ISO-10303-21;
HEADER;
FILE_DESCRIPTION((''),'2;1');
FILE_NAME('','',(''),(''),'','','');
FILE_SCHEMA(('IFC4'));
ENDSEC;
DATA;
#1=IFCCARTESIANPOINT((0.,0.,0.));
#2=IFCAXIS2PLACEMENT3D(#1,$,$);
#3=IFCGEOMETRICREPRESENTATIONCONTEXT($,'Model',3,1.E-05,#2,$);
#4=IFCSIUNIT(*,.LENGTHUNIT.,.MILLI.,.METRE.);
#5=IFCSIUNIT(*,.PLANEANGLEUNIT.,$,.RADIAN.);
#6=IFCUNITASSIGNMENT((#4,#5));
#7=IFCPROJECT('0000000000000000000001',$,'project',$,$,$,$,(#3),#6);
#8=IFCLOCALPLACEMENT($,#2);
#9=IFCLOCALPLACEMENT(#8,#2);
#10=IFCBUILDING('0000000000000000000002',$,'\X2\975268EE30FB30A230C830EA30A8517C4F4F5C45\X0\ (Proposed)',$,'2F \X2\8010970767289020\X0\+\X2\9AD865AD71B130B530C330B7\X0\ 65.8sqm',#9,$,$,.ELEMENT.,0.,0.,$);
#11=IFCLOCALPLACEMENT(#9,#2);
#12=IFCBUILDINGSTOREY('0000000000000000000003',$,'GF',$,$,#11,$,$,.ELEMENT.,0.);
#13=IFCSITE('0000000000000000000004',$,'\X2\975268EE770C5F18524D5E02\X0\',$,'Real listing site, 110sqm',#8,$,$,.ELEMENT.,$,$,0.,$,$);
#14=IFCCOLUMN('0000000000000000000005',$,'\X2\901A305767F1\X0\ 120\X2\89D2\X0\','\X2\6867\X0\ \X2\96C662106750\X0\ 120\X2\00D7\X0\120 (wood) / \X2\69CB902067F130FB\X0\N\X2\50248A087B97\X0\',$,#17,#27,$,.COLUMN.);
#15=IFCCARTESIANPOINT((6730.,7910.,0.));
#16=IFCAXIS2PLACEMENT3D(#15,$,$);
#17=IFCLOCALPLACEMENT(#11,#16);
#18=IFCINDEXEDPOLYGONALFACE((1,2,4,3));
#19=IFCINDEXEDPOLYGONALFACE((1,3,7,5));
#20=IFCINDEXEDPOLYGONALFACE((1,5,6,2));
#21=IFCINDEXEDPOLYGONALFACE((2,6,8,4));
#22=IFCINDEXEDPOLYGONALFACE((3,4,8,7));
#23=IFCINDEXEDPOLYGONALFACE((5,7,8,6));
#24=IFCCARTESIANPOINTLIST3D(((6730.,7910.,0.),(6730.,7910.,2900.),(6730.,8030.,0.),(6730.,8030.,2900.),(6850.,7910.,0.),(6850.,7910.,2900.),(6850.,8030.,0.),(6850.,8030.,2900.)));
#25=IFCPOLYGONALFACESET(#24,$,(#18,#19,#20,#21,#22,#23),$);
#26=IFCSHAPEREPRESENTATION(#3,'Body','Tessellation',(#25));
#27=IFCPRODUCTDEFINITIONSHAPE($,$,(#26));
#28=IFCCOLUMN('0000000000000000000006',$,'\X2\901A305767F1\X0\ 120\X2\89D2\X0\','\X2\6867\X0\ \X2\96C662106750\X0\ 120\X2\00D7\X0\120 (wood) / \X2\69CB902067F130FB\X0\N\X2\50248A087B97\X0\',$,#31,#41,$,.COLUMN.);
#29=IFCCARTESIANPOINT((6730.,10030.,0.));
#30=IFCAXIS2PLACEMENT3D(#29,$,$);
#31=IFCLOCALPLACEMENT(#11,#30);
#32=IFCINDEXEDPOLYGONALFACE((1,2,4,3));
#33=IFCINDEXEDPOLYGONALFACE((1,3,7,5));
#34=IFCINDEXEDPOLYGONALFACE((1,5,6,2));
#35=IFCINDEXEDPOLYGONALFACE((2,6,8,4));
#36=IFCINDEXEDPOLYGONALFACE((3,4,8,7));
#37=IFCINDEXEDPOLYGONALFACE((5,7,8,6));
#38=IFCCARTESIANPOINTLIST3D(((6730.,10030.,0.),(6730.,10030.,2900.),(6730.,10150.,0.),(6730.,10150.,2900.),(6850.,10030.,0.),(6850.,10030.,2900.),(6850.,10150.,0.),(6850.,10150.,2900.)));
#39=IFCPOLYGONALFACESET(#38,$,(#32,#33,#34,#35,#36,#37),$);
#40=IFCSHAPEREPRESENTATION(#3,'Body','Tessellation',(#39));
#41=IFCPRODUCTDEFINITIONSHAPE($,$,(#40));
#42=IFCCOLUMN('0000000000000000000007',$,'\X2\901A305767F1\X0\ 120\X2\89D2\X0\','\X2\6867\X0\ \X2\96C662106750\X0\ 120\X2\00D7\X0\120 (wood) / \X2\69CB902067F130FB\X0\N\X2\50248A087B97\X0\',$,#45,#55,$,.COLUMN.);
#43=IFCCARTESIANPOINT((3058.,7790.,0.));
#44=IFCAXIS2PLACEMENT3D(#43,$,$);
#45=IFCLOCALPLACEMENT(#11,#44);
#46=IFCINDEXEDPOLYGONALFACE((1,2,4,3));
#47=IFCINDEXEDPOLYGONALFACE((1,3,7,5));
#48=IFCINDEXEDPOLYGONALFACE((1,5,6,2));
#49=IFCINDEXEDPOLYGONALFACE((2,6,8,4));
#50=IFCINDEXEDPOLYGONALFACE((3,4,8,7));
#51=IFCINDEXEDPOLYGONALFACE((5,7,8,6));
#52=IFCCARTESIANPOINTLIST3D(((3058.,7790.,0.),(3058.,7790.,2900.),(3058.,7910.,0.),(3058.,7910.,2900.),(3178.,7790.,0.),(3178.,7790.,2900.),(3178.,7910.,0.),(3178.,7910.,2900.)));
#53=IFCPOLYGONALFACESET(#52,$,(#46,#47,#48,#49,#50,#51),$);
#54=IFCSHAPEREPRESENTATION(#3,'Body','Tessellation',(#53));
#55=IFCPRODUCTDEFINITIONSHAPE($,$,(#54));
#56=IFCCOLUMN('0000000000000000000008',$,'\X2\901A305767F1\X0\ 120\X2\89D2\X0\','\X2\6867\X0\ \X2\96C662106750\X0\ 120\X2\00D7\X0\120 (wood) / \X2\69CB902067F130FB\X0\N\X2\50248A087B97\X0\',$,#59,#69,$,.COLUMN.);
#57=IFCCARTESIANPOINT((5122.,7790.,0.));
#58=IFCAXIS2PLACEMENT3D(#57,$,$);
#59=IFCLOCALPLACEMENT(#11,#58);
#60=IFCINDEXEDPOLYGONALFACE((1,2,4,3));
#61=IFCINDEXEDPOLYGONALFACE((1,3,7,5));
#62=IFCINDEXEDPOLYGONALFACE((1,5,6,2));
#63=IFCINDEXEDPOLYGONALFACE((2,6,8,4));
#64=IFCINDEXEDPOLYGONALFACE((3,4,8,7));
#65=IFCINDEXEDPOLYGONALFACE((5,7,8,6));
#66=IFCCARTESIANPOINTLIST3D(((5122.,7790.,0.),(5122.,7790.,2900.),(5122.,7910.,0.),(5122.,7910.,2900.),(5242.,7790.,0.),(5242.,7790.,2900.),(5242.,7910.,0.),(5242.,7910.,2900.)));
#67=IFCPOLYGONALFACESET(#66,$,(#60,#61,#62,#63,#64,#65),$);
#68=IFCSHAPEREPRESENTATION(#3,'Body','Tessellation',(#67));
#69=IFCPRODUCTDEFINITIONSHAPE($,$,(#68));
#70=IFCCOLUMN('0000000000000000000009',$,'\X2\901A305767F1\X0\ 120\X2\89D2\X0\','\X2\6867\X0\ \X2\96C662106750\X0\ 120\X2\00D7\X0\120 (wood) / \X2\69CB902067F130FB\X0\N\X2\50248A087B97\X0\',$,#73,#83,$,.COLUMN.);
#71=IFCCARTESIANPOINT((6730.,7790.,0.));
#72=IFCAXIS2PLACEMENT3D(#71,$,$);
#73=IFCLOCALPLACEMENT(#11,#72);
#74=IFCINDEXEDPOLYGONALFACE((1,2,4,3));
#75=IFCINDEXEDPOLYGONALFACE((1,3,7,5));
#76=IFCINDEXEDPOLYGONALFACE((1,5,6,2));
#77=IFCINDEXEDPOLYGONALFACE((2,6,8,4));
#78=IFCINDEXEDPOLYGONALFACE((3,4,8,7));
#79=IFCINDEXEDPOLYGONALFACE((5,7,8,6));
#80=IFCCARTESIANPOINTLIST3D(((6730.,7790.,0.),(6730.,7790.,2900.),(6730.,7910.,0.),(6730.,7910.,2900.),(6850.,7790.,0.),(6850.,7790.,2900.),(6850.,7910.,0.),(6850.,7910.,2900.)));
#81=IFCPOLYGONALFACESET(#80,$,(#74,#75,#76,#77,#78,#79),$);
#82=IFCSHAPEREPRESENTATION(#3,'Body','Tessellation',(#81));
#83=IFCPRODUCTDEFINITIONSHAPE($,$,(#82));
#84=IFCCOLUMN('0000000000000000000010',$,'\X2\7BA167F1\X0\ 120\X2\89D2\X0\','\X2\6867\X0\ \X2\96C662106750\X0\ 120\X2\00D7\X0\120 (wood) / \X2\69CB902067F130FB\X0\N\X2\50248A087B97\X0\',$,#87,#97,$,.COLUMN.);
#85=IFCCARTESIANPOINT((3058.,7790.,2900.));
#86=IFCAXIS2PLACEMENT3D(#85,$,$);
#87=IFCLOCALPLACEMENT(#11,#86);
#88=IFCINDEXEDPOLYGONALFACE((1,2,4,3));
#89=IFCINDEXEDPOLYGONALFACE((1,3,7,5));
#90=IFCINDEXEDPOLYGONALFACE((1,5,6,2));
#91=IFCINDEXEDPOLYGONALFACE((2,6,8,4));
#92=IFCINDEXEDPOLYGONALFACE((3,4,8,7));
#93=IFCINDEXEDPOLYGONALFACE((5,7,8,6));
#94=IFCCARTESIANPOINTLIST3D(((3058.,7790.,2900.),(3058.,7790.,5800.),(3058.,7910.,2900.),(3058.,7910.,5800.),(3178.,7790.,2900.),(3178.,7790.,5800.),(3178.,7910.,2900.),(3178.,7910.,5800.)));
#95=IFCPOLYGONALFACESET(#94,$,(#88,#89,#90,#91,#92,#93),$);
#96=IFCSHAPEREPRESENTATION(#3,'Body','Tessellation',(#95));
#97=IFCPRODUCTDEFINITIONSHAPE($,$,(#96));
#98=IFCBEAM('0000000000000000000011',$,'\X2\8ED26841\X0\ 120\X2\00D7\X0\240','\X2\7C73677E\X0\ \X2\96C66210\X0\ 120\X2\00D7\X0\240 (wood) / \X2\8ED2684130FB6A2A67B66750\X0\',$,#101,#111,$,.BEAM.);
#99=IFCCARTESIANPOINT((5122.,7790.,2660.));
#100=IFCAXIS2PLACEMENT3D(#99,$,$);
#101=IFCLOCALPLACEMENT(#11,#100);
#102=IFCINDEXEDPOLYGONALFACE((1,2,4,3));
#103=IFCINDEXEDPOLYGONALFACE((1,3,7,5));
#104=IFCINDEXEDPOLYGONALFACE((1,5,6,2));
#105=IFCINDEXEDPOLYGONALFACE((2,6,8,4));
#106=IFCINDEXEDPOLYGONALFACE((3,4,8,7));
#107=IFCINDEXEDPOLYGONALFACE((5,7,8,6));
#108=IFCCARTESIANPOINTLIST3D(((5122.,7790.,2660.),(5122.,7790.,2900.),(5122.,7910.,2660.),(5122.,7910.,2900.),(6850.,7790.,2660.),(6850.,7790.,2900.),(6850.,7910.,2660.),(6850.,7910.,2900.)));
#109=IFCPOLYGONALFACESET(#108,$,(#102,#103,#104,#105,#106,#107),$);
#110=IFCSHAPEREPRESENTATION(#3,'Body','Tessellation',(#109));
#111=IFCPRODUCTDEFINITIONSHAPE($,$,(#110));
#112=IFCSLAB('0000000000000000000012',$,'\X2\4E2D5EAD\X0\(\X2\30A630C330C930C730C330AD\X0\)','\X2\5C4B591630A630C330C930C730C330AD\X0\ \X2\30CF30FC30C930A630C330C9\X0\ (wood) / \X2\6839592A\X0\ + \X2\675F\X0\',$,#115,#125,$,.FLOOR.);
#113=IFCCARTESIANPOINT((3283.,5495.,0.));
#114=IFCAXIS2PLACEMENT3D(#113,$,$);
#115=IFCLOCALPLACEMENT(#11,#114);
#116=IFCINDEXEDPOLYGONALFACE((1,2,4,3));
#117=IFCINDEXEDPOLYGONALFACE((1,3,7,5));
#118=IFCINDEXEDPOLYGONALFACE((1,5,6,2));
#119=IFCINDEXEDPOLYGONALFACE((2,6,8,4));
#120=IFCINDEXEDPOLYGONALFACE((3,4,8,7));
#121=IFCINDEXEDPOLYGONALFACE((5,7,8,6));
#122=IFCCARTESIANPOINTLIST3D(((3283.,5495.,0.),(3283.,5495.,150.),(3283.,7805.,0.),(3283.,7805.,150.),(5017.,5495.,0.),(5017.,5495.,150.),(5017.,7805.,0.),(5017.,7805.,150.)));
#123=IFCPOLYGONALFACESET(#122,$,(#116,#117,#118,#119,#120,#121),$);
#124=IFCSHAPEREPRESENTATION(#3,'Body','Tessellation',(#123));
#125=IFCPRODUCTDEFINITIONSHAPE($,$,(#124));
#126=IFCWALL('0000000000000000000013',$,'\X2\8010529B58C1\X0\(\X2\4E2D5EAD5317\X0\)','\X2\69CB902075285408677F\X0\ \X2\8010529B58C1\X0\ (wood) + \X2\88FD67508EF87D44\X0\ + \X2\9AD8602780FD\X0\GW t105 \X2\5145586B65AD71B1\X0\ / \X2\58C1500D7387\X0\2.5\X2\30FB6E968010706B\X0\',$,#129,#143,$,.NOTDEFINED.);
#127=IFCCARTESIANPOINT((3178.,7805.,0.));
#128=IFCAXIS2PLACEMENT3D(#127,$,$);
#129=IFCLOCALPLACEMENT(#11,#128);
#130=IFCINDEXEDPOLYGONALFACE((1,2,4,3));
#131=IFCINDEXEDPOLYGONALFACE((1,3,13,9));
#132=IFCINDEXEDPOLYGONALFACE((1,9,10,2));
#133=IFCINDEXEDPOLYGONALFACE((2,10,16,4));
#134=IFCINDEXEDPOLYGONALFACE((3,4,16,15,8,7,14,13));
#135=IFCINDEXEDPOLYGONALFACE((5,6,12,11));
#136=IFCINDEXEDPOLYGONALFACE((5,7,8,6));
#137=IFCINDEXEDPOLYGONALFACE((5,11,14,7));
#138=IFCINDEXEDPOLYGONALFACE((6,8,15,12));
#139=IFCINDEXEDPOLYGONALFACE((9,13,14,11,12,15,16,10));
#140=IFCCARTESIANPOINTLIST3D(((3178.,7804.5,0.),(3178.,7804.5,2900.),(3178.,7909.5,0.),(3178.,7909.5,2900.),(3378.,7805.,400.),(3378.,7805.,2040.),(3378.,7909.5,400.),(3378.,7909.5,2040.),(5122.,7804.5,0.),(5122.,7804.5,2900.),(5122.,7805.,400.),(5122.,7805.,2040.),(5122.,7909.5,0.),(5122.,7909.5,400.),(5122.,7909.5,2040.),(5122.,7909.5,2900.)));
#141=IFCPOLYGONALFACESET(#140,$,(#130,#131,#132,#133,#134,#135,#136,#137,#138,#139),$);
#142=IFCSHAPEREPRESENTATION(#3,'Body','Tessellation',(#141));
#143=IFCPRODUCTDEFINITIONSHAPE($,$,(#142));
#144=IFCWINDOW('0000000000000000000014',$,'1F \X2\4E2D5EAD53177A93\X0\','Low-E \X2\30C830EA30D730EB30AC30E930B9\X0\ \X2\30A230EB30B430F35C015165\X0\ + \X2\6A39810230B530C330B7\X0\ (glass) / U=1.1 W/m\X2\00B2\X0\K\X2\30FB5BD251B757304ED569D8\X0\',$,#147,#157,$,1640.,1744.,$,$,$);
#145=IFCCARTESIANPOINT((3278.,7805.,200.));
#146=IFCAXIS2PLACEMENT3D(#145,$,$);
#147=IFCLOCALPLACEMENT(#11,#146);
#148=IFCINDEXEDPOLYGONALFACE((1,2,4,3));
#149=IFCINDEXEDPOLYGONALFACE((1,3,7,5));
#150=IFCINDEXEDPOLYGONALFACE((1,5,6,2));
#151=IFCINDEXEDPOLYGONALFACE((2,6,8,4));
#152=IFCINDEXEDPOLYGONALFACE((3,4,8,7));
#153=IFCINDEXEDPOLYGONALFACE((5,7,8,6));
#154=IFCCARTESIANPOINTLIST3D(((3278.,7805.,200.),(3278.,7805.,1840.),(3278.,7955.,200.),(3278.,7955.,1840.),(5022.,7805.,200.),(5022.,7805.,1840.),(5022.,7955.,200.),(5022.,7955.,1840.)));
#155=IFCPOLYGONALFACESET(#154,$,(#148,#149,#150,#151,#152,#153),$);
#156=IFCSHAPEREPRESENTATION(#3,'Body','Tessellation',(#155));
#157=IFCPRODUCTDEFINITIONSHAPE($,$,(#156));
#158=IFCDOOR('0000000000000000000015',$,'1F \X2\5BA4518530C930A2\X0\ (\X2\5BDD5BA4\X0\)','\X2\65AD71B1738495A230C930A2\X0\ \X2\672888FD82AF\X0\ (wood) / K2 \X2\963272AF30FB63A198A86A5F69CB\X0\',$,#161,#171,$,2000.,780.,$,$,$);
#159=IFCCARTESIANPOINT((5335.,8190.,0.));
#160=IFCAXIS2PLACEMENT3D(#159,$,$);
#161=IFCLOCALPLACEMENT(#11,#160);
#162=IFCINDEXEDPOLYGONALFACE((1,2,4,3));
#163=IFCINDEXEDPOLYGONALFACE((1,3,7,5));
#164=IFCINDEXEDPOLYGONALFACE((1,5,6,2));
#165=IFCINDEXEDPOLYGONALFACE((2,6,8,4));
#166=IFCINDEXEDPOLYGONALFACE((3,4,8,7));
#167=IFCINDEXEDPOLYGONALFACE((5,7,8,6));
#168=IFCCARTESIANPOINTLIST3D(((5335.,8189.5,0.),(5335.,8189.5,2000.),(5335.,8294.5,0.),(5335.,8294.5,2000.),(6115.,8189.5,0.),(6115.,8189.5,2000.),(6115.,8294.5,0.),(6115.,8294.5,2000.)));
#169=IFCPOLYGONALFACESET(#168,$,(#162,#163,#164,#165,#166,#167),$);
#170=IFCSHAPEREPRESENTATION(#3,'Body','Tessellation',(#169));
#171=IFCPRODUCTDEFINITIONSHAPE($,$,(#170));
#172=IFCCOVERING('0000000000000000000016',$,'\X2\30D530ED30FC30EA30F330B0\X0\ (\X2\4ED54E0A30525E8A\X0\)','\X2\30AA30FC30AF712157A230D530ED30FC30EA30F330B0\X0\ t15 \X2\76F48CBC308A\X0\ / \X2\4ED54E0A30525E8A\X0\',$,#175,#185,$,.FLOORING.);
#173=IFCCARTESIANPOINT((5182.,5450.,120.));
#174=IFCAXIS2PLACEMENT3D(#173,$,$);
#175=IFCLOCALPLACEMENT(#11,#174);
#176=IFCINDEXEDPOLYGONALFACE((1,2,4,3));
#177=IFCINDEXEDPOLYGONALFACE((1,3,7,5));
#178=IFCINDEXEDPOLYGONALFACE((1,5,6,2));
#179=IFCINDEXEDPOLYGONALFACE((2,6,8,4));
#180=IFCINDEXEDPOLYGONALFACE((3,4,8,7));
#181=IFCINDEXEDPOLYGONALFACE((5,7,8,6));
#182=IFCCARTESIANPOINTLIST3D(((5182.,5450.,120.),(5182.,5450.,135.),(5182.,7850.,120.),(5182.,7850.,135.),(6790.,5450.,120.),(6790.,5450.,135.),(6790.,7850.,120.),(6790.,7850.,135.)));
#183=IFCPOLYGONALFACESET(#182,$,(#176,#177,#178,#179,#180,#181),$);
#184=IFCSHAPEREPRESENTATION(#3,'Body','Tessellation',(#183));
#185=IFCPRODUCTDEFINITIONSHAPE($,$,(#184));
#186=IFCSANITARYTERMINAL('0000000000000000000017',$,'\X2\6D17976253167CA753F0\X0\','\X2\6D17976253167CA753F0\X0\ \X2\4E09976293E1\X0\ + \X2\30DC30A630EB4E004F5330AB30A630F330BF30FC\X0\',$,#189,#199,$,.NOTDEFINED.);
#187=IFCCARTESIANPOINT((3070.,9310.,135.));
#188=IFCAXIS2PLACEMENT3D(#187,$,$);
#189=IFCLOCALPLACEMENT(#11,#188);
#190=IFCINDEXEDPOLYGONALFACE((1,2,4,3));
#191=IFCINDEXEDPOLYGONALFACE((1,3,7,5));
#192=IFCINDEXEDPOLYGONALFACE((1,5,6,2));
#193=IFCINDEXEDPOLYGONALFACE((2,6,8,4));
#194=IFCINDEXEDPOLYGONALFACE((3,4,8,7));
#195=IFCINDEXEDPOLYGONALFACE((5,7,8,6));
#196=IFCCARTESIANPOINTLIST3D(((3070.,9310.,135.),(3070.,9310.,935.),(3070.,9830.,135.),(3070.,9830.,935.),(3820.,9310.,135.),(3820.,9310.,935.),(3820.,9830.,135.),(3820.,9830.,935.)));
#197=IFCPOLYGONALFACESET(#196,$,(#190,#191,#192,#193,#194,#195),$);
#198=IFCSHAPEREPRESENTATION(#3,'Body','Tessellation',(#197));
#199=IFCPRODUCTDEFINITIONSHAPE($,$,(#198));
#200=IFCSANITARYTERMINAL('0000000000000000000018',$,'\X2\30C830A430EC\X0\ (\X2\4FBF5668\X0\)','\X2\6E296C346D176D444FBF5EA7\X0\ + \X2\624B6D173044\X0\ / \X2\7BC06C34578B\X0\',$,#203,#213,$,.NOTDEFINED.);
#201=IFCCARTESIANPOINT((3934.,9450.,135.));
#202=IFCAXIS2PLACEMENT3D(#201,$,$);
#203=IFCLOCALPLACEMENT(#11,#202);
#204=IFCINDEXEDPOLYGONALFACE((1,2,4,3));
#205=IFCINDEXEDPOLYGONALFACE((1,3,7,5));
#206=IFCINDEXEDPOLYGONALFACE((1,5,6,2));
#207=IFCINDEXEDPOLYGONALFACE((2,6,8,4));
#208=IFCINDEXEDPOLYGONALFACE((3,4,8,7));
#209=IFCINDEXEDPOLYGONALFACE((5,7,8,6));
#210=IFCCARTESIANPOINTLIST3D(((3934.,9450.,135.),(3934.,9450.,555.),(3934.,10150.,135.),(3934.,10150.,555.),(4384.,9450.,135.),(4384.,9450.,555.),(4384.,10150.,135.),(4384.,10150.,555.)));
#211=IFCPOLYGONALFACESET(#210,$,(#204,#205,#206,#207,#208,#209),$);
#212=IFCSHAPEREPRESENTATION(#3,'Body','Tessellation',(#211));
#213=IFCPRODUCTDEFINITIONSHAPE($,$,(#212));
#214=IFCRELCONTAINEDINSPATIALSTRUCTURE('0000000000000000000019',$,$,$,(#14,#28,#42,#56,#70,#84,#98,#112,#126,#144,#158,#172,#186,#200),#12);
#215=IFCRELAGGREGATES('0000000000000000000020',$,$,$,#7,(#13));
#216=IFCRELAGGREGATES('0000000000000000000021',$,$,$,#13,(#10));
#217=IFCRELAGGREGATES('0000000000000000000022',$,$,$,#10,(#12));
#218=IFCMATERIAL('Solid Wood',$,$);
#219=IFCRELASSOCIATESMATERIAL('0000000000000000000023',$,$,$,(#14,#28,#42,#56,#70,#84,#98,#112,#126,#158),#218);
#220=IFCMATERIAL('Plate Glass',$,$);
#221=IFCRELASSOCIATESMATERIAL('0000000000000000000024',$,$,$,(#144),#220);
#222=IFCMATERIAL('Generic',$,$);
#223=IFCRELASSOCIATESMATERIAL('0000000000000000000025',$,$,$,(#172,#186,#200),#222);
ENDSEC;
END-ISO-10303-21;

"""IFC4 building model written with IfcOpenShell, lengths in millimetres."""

from ifc_helpers import new_model, si_unit, frame, frame_2d, origin, place, context, project, spatial, rectangle, extrude, material, element, fill, save


model = new_model("IFC4")

# Units and contexts
model_context = context("Model", 3, precision=1e-05, world=origin())
ifc_project = project(units=[si_unit("LENGTHUNIT", "METRE", prefix="MILLI"), si_unit("PLANEANGLEUNIT", "RADIAN")], contexts=[model_context])

# Site, building, storey
site_placement = place(None, origin())
site = spatial("IfcSite", under=ifc_project, at=site_placement, Name="青森県弘前市", ObjectType="Real listing site, 110sqm", CompositionType="ELEMENT", RefElevation=0.0)
building_placement = place(site_placement, origin())
building = spatial("IfcBuilding", under=site, at=building_placement, Name="青森・アトリエ兼住居 (Proposed)", ObjectType="2F 耐震木造+高断熱サッシ 65.8sqm", CompositionType="ELEMENT", ElevationOfRefHeight=0.0, ElevationOfTerrain=0.0)
storey_placement = place(building_placement, origin())
storey = spatial("IfcBuildingStorey", under=building, at=storey_placement, Name="GF", CompositionType="ELEMENT", Elevation=0.0)

# Columns
ifc_material_1 = material(Name="Solid Wood")
column_1_placement = place(storey_placement, frame((6730.0, 7910.0, 0.0)))
element("IfcColumn", 1, at=column_1_placement, inside=storey, material=ifc_material_1, Name="通し柱 120角", Description="桧 集成材 120×120 (wood) / 構造柱・N値計算", PredefinedType="COLUMN", context=model_context, shape_type="SweptSolid", body=[
    extrude(rectangle(XDim=120.0, YDim=120.0, at=frame_2d((60.0, 60.0))), frame((6730.0, 7910.0, 0.0)), (0.0, 0.0, 1.0), 2900.0),
])
column_2_placement = place(storey_placement, frame((6730.0, 10030.0, 0.0)))
element("IfcColumn", 2, at=column_2_placement, inside=storey, material=ifc_material_1, Name="通し柱 120角", Description="桧 集成材 120×120 (wood) / 構造柱・N値計算", PredefinedType="COLUMN", context=model_context, shape_type="SweptSolid", body=[
    extrude(rectangle(XDim=120.0, YDim=120.0, at=frame_2d((60.0, 60.0))), frame((6730.0, 10030.0, 0.0)), (0.0, 0.0, 1.0), 2900.0),
])
column_3_placement = place(storey_placement, frame((3058.0, 7790.0, 0.0)))
element("IfcColumn", 3, at=column_3_placement, inside=storey, material=ifc_material_1, Name="通し柱 120角", Description="桧 集成材 120×120 (wood) / 構造柱・N値計算", PredefinedType="COLUMN", context=model_context, shape_type="SweptSolid", body=[
    extrude(rectangle(XDim=120.0, YDim=120.0, at=frame_2d((60.0, 60.0))), frame((3058.0, 7790.0, 0.0)), (0.0, 0.0, 1.0), 2900.0),
])
column_4_placement = place(storey_placement, frame((5122.0, 7790.0, 0.0)))
element("IfcColumn", 4, at=column_4_placement, inside=storey, material=ifc_material_1, Name="通し柱 120角", Description="桧 集成材 120×120 (wood) / 構造柱・N値計算", PredefinedType="COLUMN", context=model_context, shape_type="SweptSolid", body=[
    extrude(rectangle(XDim=120.0, YDim=120.0, at=frame_2d((60.0, 60.0))), frame((5122.0, 7790.0, 0.0)), (0.0, 0.0, 1.0), 2900.0),
])
column_5_placement = place(storey_placement, frame((6730.0, 7790.0, 0.0)))
element("IfcColumn", 5, at=column_5_placement, inside=storey, material=ifc_material_1, Name="通し柱 120角", Description="桧 集成材 120×120 (wood) / 構造柱・N値計算", PredefinedType="COLUMN", context=model_context, shape_type="SweptSolid", body=[
    extrude(rectangle(XDim=120.0, YDim=120.0, at=frame_2d((60.0, 60.0))), frame((6730.0, 7790.0, 0.0)), (0.0, 0.0, 1.0), 2900.0),
])
column_6_placement = place(storey_placement, frame((3058.0, 7790.0, 2900.0)))
element("IfcColumn", 6, at=column_6_placement, inside=storey, material=ifc_material_1, Name="管柱 120角", Description="桧 集成材 120×120 (wood) / 構造柱・N値計算", PredefinedType="COLUMN", context=model_context, shape_type="SweptSolid", body=[
    extrude(rectangle(XDim=120.0, YDim=120.0, at=frame_2d((60.0, 60.0))), frame((3058.0, 7790.0, 2900.0)), (0.0, 0.0, 1.0), 2900.0),
])

# Beam
beam_1_placement = place(storey_placement, frame((5122.0, 7790.0, 2660.0)))
element("IfcBeam", 7, at=beam_1_placement, inside=storey, material=ifc_material_1, Name="軒桁 120×240", Description="米松 集成 120×240 (wood) / 軒桁・横架材", PredefinedType="BEAM", context=model_context, shape_type="SweptSolid", body=[
    extrude(rectangle(XDim=1728.0, YDim=120.0, at=frame_2d((864.0, 60.0))), frame((5122.0, 7790.0, 2660.0)), (0.0, 0.0, 1.0), 240.0),
])

# Slab
slab_placement = place(storey_placement, frame((3283.0, 5495.0, 0.0)))
element("IfcSlab", 8, at=slab_placement, inside=storey, material=ifc_material_1, Name="中庭(ウッドデッキ)", Description="屋外ウッドデッキ ハードウッド (wood) / 根太 + 束", PredefinedType="FLOOR", context=model_context, shape_type="SweptSolid", body=[
    extrude(rectangle(XDim=1734.0, YDim=2310.0, at=frame_2d((867.0, 1155.0))), frame((3283.0, 5495.0, 0.0)), (0.0, 0.0, 1.0), 150.0),
])

# Wall, opening, window
wall_1_placement = place(storey_placement, frame((3178.0, 7805.0, 0.0)))
wall_1 = element("IfcWall", 9, at=wall_1_placement, inside=storey, material=ifc_material_1, Name="耐力壁(中庭北)", Description="構造用合板 耐力壁 (wood) + 製材軸組 + 高性能GW t105 充填断熱 / 壁倍率2.5・準耐火", PredefinedType="NOTDEFINED", context=model_context, shape_type="SweptSolid", body=[
    extrude(rectangle(XDim=1944.0, YDim=105.0, at=frame_2d((972.0, 52.0))), frame((3178.0, 7805.0, 0.0)), (0.0, 0.0, 1.0), 2900.0),
])
opening_placement = place(storey_placement, frame((3278.0, 7805.0, 200.0)))
opening = element("IfcOpeningElement", 10, at=opening_placement, cuts=wall_1, PredefinedType="NOTDEFINED", context=model_context, shape_type="SweptSolid", body=[
    extrude(rectangle(XDim=1744.0, YDim=150.0, at=frame_2d((872.0, 75.0))), frame((3278.0, 7805.0, 200.0)), (0.0, 0.0, 1.0), 1640.0),
])
ifc_material_2 = material(Name="Plate Glass")
window_placement = place(storey_placement, frame((3278.0, 7805.0, 200.0)))
window = element("IfcWindow", 11, at=window_placement, inside=storey, material=ifc_material_2, Name="1F 中庭北窓", Description="Low-E トリプルガラス アルゴン封入 + 樹脂サッシ (glass) / U=1.1 W/m²K・寒冷地仕様", OverallHeight=1640.0, OverallWidth=1744.0, context=model_context, shape_type="SweptSolid", body=[
    extrude(rectangle(XDim=1744.0, YDim=150.0, at=frame_2d((872.0, 75.0))), frame((3278.0, 7805.0, 200.0)), (0.0, 0.0, 1.0), 1640.0),
])
fill(opening, window)

# Door
door_placement = place(storey_placement, frame((5335.0, 8190.0, 0.0)))
element("IfcDoor", 12, at=door_placement, inside=storey, material=ifc_material_1, Name="1F 室内ドア (寝室)", Description="断熱玄関ドア 木製芯 (wood) / K2 防犯・採風機構", OverallHeight=2000.0, OverallWidth=780.0, context=model_context, shape_type="SweptSolid", body=[
    extrude(rectangle(XDim=780.0, YDim=105.0, at=frame_2d((390.0, 52.0))), frame((5335.0, 8190.0, 0.0)), (0.0, 0.0, 1.0), 2000.0),
])

# Covering
ifc_material_3 = material(Name="Generic")
covering_placement = place(storey_placement, frame((5182.0, 5450.0, 120.0)))
element("IfcCovering", 13, at=covering_placement, inside=storey, material=ifc_material_3, Name="フローリング (仕上げ床)", Description="オーク無垢フローリング t15 直貼り / 仕上げ床", PredefinedType="FLOORING", context=model_context, shape_type="SweptSolid", body=[
    extrude(rectangle(XDim=1608.0, YDim=2400.0, at=frame_2d((804.0, 1200.0))), frame((5182.0, 5450.0, 120.0)), (0.0, 0.0, 1.0), 15.0),
])

# Sanitary terminals
sanitary_terminal_1_placement = place(storey_placement, frame((3070.0, 9310.0, 135.0)))
element("IfcSanitaryTerminal", 14, at=sanitary_terminal_1_placement, inside=storey, material=ifc_material_3, Name="洗面化粧台", Description="洗面化粧台 三面鏡 + ボウル一体カウンター", PredefinedType="NOTDEFINED", context=model_context, shape_type="SweptSolid", body=[
    extrude(rectangle(XDim=750.0, YDim=520.0, at=frame_2d((375.0, 260.0))), frame((3070.0, 9310.0, 135.0)), (0.0, 0.0, 1.0), 800.0),
])
sanitary_terminal_2_placement = place(storey_placement, frame((3934.0, 9450.0, 135.0)))
element("IfcSanitaryTerminal", 15, at=sanitary_terminal_2_placement, inside=storey, material=ifc_material_3, Name="トイレ (便器)", Description="温水洗浄便座 + 手洗い / 節水型", PredefinedType="NOTDEFINED", context=model_context, shape_type="SweptSolid", body=[
    extrude(rectangle(XDim=450.0, YDim=700.0, at=frame_2d((225.0, 350.0))), frame((3934.0, 9450.0, 135.0)), (0.0, 0.0, 1.0), 420.0),
])

save(model, "model.ifc")
